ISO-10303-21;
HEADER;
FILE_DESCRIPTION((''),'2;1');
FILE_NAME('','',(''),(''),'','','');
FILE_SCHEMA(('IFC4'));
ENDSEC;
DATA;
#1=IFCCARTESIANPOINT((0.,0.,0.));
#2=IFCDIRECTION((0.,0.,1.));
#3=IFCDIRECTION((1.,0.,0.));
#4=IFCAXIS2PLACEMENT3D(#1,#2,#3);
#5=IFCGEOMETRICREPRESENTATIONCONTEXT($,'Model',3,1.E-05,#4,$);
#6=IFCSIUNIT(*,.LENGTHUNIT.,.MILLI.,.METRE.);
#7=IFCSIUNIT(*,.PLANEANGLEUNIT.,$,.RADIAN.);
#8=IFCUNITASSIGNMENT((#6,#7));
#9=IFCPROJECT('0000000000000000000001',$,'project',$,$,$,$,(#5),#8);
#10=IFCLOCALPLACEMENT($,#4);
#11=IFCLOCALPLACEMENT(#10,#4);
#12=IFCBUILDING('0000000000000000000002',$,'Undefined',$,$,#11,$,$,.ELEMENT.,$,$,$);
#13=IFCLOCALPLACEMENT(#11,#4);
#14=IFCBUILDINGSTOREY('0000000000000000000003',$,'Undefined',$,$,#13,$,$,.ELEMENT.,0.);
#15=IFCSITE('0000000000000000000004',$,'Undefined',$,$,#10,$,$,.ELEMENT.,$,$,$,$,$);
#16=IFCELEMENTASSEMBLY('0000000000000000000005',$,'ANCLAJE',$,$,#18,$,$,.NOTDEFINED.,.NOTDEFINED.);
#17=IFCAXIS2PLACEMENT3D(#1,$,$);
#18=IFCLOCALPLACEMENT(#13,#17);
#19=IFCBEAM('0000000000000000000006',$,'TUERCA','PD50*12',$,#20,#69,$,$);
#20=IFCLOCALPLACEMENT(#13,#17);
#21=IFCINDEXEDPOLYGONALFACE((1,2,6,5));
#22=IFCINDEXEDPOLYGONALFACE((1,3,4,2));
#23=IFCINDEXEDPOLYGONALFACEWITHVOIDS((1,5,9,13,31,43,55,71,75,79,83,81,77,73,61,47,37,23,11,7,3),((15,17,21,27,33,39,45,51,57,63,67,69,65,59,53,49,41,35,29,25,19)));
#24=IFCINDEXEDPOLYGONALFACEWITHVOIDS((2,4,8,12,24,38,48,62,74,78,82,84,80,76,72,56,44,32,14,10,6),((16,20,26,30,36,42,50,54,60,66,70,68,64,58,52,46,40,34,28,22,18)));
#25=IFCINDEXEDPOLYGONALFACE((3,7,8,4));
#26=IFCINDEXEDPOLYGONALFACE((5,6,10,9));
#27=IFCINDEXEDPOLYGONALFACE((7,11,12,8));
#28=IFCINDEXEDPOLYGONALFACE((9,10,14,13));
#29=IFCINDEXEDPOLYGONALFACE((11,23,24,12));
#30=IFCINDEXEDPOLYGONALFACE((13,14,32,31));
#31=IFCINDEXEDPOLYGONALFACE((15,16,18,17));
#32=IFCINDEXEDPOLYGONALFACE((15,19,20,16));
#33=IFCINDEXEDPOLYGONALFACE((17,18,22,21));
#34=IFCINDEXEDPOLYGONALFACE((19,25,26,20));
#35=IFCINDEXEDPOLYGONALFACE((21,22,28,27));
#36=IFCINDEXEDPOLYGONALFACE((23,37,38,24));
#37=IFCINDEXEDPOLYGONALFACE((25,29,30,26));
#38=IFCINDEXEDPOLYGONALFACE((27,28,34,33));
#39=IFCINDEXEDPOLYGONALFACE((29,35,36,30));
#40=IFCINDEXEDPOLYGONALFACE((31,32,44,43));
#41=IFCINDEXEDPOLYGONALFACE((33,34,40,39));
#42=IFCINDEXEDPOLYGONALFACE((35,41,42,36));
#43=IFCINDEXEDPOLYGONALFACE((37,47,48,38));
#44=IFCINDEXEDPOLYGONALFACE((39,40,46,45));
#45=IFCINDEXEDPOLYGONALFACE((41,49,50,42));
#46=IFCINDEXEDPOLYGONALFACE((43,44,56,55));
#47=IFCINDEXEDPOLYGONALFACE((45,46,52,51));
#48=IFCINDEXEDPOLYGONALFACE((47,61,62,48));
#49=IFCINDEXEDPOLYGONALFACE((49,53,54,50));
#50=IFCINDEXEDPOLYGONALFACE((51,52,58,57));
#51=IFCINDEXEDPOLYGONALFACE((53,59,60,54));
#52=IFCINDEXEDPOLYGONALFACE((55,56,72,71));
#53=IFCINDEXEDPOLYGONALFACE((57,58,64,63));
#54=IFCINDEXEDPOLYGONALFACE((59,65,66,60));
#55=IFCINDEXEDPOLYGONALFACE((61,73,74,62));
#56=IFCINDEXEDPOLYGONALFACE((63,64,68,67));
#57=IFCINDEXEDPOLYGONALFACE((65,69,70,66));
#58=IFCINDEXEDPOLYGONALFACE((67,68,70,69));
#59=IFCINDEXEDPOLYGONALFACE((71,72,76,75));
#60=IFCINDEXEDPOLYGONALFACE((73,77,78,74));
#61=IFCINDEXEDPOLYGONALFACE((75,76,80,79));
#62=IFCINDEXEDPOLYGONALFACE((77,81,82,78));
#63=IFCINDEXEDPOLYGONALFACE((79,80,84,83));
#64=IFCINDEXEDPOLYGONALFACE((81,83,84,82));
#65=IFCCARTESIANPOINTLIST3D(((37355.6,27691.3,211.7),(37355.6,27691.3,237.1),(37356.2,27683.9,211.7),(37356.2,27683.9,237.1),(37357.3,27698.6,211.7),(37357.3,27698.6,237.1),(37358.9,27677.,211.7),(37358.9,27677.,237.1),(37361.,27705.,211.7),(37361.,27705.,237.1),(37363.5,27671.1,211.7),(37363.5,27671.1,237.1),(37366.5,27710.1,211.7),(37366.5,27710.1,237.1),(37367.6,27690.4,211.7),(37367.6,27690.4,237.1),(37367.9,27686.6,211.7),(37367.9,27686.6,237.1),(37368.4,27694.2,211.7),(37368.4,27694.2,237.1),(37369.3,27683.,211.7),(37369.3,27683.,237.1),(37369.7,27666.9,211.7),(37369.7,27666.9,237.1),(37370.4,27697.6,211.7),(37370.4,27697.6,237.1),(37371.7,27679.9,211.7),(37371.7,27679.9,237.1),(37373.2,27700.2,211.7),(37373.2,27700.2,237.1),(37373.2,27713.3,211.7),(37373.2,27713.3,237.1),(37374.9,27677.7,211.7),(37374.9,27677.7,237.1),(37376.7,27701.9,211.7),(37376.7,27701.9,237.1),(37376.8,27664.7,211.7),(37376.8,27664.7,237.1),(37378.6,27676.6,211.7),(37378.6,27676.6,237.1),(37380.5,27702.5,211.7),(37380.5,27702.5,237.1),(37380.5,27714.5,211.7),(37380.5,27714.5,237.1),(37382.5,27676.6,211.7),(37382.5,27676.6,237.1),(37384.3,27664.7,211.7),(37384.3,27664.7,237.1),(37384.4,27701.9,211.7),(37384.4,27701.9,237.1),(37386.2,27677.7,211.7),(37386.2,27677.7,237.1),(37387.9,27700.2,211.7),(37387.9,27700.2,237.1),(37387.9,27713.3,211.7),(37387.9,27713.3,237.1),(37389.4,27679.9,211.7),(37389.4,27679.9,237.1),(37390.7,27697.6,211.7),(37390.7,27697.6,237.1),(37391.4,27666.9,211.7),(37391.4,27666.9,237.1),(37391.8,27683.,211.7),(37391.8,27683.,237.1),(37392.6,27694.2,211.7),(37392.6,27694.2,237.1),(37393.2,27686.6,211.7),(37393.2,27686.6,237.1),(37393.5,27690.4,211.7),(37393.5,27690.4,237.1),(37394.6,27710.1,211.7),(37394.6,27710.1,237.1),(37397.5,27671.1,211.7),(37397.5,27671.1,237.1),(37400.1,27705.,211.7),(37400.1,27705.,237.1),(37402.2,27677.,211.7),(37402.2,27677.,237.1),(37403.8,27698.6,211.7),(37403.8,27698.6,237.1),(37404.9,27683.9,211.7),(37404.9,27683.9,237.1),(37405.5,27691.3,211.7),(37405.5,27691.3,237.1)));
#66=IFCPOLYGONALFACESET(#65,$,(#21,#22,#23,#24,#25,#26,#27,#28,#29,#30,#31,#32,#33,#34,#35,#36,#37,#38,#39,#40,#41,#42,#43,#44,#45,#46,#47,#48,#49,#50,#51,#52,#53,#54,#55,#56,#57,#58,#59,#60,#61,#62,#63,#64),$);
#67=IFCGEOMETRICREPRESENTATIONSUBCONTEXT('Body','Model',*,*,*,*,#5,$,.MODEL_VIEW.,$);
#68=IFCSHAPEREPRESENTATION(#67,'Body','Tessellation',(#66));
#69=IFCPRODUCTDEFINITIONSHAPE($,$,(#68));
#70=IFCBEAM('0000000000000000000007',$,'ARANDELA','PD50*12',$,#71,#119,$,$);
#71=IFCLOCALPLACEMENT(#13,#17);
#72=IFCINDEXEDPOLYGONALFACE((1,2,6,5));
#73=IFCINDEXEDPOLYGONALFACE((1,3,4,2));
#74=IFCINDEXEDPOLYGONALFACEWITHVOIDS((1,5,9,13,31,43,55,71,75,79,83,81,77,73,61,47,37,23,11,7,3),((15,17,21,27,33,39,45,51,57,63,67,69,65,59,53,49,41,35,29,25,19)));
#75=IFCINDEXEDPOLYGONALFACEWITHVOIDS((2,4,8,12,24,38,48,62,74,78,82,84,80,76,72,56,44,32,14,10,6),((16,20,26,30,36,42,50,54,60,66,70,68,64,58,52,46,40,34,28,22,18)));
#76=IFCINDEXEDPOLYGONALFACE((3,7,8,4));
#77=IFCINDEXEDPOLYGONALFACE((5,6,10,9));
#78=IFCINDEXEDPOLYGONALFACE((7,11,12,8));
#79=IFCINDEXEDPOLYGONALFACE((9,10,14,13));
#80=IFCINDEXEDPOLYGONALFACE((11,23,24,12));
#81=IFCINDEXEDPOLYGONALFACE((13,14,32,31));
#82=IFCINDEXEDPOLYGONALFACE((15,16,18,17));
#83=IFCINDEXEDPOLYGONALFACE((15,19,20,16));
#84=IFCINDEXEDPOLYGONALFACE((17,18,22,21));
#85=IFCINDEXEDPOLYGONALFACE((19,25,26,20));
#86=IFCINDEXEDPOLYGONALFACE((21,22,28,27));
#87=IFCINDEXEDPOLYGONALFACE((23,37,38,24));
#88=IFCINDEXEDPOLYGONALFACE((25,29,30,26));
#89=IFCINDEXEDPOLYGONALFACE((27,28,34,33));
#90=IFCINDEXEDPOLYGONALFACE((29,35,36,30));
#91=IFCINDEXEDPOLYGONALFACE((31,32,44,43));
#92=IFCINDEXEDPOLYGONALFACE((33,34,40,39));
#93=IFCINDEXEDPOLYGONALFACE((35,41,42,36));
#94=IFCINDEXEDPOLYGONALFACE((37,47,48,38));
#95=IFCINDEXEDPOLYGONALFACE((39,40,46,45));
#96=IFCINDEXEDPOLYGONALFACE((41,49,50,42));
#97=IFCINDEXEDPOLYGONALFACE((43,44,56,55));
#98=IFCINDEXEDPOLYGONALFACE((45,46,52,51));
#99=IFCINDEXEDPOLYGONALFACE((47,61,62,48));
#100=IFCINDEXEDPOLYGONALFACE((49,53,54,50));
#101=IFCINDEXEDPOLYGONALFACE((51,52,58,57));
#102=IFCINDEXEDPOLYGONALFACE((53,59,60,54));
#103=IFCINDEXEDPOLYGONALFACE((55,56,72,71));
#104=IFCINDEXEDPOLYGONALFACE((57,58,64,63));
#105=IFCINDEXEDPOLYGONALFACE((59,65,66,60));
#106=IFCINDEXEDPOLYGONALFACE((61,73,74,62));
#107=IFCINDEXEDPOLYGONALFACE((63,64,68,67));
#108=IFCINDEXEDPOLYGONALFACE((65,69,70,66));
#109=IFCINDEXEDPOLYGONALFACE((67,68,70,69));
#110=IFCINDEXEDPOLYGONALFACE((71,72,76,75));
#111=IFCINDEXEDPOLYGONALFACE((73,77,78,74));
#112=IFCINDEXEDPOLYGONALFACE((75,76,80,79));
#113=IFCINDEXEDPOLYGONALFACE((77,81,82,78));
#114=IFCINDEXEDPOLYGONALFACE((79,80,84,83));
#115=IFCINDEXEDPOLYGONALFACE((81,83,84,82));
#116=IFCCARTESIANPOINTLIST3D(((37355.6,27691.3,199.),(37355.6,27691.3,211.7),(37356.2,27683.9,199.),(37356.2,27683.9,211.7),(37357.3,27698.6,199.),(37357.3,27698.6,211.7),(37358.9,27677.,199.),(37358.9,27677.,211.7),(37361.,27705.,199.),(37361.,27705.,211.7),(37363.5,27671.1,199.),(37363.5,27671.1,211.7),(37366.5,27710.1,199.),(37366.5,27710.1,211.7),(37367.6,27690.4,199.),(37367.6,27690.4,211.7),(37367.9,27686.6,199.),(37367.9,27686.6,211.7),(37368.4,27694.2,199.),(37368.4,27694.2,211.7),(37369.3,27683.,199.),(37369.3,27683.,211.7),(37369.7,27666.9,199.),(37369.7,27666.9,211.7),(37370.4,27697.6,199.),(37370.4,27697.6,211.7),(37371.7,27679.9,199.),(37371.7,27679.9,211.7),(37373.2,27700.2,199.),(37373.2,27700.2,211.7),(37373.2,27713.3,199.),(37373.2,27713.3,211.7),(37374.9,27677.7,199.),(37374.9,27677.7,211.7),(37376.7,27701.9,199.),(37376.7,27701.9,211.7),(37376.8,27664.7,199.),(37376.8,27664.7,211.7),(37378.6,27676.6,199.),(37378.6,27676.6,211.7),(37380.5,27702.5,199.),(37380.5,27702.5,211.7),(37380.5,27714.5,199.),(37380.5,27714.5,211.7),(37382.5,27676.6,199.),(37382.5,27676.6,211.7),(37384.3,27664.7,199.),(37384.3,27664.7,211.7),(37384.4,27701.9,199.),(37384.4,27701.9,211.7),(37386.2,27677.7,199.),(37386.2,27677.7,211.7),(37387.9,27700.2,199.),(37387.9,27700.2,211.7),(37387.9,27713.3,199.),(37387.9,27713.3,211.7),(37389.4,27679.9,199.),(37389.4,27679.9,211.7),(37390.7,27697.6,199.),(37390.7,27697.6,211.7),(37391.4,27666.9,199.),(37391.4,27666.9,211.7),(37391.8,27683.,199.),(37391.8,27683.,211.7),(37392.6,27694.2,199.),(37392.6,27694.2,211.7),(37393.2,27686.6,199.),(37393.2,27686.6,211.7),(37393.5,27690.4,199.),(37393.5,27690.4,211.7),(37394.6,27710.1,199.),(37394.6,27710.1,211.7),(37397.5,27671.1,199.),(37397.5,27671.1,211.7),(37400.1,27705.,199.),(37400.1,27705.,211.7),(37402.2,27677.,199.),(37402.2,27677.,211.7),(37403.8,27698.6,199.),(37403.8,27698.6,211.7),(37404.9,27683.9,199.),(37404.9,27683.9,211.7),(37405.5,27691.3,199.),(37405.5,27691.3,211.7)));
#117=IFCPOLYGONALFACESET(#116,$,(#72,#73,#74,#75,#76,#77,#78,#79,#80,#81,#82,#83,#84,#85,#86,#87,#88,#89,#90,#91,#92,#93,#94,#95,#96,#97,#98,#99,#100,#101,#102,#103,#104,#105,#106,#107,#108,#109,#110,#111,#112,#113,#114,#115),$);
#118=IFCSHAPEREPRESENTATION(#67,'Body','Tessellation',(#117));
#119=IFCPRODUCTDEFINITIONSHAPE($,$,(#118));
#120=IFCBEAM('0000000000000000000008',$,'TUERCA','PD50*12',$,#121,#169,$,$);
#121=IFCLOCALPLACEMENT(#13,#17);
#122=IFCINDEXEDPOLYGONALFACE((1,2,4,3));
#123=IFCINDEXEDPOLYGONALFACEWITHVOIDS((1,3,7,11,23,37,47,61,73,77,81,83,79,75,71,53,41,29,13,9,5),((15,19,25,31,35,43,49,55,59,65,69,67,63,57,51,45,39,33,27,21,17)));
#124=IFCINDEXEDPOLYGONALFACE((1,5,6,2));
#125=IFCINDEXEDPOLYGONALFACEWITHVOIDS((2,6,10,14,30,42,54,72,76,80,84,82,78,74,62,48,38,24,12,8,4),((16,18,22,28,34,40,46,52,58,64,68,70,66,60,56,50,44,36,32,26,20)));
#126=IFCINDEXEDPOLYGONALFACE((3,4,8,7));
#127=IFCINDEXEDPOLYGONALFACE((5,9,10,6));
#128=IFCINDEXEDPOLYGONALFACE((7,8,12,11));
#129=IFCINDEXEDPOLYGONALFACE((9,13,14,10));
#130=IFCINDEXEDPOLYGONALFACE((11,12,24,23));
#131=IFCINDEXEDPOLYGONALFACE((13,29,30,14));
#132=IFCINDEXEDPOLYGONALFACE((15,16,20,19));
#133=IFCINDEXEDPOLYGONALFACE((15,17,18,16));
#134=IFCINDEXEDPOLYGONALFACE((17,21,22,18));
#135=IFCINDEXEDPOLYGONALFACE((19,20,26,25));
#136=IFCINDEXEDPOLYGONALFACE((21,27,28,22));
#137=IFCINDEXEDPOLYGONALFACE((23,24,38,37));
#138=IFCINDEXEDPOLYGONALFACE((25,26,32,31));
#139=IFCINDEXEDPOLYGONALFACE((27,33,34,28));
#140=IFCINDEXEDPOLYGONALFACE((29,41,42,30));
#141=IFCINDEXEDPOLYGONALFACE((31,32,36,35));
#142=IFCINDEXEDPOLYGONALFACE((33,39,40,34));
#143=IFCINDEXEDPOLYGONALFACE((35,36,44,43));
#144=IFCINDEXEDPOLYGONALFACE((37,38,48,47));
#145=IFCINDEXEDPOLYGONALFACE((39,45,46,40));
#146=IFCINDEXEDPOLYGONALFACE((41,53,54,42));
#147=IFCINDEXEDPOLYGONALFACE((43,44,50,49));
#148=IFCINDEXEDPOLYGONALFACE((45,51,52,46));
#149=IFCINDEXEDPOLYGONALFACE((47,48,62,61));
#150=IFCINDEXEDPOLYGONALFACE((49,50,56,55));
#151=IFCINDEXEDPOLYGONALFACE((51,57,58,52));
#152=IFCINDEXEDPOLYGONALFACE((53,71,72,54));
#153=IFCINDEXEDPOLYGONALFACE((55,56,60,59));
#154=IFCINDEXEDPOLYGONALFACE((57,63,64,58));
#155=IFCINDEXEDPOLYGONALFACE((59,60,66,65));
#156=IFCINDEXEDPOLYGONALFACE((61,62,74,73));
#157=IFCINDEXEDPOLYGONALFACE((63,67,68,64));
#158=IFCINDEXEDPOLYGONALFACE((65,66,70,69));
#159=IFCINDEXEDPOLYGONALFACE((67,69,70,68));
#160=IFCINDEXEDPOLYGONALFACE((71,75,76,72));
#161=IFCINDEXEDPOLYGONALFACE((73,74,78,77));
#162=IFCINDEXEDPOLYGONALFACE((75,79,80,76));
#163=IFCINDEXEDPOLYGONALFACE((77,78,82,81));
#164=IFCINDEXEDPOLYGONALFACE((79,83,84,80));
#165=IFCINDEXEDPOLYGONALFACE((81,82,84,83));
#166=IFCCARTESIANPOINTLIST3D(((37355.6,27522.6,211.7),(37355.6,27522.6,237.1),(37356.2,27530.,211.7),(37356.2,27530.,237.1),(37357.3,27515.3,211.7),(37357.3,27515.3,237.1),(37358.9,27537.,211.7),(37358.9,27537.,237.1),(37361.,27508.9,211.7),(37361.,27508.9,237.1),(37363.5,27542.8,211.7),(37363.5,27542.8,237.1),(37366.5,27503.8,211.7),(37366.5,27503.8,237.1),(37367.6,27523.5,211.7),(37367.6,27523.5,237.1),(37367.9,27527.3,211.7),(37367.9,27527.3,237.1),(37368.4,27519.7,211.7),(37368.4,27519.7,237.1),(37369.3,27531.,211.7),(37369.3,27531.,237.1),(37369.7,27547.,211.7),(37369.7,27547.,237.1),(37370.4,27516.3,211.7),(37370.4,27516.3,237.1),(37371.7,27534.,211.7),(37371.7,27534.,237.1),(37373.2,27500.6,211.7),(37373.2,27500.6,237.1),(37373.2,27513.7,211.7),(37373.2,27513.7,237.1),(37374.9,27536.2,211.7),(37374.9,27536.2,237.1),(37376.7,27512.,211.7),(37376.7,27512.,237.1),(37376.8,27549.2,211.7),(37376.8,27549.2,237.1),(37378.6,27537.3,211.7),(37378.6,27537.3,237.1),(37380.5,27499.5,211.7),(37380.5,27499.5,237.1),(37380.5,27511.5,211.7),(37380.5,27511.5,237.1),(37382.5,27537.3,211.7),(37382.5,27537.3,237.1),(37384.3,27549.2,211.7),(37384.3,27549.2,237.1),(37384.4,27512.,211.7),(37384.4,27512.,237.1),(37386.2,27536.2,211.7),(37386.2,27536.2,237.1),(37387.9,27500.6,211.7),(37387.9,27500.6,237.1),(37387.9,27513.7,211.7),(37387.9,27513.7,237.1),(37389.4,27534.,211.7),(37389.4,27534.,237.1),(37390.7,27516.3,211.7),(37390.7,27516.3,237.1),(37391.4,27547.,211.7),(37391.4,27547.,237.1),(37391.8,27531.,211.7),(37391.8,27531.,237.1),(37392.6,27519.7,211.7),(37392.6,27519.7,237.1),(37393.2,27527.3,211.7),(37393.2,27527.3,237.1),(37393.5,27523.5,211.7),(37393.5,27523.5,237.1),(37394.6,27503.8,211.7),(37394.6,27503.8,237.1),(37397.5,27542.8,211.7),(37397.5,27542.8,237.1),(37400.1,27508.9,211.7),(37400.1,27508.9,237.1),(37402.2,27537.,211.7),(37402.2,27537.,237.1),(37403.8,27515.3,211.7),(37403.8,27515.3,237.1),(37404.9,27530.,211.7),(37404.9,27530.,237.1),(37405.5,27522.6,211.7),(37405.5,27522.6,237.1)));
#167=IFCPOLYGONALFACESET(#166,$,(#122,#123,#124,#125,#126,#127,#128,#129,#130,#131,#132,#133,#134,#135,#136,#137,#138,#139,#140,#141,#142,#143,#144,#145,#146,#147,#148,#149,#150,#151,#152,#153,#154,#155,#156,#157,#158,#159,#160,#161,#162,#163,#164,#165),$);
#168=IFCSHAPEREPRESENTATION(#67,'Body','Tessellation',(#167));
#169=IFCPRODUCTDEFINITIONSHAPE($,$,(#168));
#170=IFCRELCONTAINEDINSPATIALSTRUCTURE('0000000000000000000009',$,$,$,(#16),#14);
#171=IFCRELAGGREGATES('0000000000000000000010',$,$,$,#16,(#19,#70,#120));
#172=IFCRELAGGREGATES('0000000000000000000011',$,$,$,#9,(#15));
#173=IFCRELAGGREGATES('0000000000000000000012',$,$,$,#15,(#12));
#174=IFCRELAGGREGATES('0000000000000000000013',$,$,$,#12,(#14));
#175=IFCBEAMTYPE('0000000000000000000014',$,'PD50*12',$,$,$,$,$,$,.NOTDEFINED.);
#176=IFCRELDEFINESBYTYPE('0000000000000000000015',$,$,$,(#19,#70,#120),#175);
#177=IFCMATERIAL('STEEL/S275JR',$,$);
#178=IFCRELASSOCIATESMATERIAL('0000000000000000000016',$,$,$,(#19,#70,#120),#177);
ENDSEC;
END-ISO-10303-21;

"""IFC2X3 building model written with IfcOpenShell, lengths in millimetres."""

from ifc_helpers import new_model, si_unit, frame, origin_with_axes, origin_2d_with_axis, place, context, subcontext, project, spatial, hollow_circle, extrude, material, type_object, element, aggregate, save


model = new_model("IFC2X3")

# Units and contexts
model_context = context("Model", 3, precision=1e-05, world=origin_with_axes())
body_context = subcontext(model_context, "Body", "Model", "MODEL_VIEW")
ifc_project = project(units=[si_unit("LENGTHUNIT", "METRE", prefix="MILLI"), si_unit("PLANEANGLEUNIT", "RADIAN")], contexts=[model_context])

# Site, building, storey
site_placement = place(None, origin_with_axes())
site = spatial("IfcSite", under=ifc_project, at=site_placement, Name="Undefined", CompositionType="ELEMENT")
building_placement = place(site_placement, origin_with_axes())
building = spatial("IfcBuilding", under=site, at=building_placement, Name="Undefined", CompositionType="ELEMENT")
storey_placement = place(building_placement, origin_with_axes())
storey = spatial("IfcBuildingStorey", under=building, at=storey_placement, Name="Undefined", CompositionType="ELEMENT", Elevation=0.0)

# Element assembly, beams
assembly_1_placement = place(storey_placement, origin_with_axes())
assembly_1 = element("IfcElementAssembly", 1, at=assembly_1_placement, inside=storey, Name="ANCLAJE", AssemblyPlace="NOTDEFINED", PredefinedType="NOTDEFINED")
ifc_material_1 = material(Name="STEEL/S275JR")
beam_type_1 = type_object("IfcBeamType", Name="PD50*12", PredefinedType="NOTDEFINED")
beam_1_placement = place(assembly_1_placement, frame((37380.5, 27689.5, 237.1), z_axis=(-1.0, 0.0, 0.0), x_axis=(0.0, 0.0, -1.0)))
beam_1 = element("IfcBeam", 2, at=beam_1_placement, type_object=beam_type_1, material=ifc_material_1, Name="TUERCA", Description="PD50*12", context=body_context, shape_type="SweptSolid", body=[
    extrude(hollow_circle(Radius=25.0, WallThickness=12.0, at=origin_2d_with_axis()), frame((25.4, 0.0, 0.0), z_axis=(-1.0, 0.0, 0.0), x_axis=(0.0, -1.0, 0.0)), (0.0, 0.0, 1.0), 25.4),
])
beam_2_placement = place(assembly_1_placement, frame((37380.5, 27689.5, 211.7), z_axis=(-1.0, 0.0, 0.0), x_axis=(0.0, 0.0, -1.0)))
beam_2 = element("IfcBeam", 3, at=beam_2_placement, type_object=beam_type_1, material=ifc_material_1, Name="ARANDELA", Description="PD50*12", context=body_context, shape_type="SweptSolid", body=[
    extrude(hollow_circle(Radius=25.0, WallThickness=12.0, at=origin_2d_with_axis()), frame((12.7, 0.0, 0.0), z_axis=(-1.0, 0.0, 0.0), x_axis=(0.0, -1.0, 0.0)), (0.0, 0.0, 1.0), 12.7),
])
beam_3_placement = place(assembly_1_placement, frame((37380.5, 27524.5, 237.1), z_axis=(1.0, 0.0, 0.0), x_axis=(0.0, 0.0, -1.0)))
beam_3 = element("IfcBeam", 4, at=beam_3_placement, type_object=beam_type_1, material=ifc_material_1, Name="TUERCA", Description="PD50*12", context=body_context, shape_type="SweptSolid", body=[
    extrude(hollow_circle(Radius=25.0, WallThickness=12.0, at=origin_2d_with_axis()), frame((25.4, 0.0, 0.0), z_axis=(-1.0, 0.0, 0.0), x_axis=(0.0, -1.0, 0.0)), (0.0, 0.0, 1.0), 25.4),
])

aggregate(assembly_1, [beam_1, beam_2, beam_3])

save(model, "model.ifc")
